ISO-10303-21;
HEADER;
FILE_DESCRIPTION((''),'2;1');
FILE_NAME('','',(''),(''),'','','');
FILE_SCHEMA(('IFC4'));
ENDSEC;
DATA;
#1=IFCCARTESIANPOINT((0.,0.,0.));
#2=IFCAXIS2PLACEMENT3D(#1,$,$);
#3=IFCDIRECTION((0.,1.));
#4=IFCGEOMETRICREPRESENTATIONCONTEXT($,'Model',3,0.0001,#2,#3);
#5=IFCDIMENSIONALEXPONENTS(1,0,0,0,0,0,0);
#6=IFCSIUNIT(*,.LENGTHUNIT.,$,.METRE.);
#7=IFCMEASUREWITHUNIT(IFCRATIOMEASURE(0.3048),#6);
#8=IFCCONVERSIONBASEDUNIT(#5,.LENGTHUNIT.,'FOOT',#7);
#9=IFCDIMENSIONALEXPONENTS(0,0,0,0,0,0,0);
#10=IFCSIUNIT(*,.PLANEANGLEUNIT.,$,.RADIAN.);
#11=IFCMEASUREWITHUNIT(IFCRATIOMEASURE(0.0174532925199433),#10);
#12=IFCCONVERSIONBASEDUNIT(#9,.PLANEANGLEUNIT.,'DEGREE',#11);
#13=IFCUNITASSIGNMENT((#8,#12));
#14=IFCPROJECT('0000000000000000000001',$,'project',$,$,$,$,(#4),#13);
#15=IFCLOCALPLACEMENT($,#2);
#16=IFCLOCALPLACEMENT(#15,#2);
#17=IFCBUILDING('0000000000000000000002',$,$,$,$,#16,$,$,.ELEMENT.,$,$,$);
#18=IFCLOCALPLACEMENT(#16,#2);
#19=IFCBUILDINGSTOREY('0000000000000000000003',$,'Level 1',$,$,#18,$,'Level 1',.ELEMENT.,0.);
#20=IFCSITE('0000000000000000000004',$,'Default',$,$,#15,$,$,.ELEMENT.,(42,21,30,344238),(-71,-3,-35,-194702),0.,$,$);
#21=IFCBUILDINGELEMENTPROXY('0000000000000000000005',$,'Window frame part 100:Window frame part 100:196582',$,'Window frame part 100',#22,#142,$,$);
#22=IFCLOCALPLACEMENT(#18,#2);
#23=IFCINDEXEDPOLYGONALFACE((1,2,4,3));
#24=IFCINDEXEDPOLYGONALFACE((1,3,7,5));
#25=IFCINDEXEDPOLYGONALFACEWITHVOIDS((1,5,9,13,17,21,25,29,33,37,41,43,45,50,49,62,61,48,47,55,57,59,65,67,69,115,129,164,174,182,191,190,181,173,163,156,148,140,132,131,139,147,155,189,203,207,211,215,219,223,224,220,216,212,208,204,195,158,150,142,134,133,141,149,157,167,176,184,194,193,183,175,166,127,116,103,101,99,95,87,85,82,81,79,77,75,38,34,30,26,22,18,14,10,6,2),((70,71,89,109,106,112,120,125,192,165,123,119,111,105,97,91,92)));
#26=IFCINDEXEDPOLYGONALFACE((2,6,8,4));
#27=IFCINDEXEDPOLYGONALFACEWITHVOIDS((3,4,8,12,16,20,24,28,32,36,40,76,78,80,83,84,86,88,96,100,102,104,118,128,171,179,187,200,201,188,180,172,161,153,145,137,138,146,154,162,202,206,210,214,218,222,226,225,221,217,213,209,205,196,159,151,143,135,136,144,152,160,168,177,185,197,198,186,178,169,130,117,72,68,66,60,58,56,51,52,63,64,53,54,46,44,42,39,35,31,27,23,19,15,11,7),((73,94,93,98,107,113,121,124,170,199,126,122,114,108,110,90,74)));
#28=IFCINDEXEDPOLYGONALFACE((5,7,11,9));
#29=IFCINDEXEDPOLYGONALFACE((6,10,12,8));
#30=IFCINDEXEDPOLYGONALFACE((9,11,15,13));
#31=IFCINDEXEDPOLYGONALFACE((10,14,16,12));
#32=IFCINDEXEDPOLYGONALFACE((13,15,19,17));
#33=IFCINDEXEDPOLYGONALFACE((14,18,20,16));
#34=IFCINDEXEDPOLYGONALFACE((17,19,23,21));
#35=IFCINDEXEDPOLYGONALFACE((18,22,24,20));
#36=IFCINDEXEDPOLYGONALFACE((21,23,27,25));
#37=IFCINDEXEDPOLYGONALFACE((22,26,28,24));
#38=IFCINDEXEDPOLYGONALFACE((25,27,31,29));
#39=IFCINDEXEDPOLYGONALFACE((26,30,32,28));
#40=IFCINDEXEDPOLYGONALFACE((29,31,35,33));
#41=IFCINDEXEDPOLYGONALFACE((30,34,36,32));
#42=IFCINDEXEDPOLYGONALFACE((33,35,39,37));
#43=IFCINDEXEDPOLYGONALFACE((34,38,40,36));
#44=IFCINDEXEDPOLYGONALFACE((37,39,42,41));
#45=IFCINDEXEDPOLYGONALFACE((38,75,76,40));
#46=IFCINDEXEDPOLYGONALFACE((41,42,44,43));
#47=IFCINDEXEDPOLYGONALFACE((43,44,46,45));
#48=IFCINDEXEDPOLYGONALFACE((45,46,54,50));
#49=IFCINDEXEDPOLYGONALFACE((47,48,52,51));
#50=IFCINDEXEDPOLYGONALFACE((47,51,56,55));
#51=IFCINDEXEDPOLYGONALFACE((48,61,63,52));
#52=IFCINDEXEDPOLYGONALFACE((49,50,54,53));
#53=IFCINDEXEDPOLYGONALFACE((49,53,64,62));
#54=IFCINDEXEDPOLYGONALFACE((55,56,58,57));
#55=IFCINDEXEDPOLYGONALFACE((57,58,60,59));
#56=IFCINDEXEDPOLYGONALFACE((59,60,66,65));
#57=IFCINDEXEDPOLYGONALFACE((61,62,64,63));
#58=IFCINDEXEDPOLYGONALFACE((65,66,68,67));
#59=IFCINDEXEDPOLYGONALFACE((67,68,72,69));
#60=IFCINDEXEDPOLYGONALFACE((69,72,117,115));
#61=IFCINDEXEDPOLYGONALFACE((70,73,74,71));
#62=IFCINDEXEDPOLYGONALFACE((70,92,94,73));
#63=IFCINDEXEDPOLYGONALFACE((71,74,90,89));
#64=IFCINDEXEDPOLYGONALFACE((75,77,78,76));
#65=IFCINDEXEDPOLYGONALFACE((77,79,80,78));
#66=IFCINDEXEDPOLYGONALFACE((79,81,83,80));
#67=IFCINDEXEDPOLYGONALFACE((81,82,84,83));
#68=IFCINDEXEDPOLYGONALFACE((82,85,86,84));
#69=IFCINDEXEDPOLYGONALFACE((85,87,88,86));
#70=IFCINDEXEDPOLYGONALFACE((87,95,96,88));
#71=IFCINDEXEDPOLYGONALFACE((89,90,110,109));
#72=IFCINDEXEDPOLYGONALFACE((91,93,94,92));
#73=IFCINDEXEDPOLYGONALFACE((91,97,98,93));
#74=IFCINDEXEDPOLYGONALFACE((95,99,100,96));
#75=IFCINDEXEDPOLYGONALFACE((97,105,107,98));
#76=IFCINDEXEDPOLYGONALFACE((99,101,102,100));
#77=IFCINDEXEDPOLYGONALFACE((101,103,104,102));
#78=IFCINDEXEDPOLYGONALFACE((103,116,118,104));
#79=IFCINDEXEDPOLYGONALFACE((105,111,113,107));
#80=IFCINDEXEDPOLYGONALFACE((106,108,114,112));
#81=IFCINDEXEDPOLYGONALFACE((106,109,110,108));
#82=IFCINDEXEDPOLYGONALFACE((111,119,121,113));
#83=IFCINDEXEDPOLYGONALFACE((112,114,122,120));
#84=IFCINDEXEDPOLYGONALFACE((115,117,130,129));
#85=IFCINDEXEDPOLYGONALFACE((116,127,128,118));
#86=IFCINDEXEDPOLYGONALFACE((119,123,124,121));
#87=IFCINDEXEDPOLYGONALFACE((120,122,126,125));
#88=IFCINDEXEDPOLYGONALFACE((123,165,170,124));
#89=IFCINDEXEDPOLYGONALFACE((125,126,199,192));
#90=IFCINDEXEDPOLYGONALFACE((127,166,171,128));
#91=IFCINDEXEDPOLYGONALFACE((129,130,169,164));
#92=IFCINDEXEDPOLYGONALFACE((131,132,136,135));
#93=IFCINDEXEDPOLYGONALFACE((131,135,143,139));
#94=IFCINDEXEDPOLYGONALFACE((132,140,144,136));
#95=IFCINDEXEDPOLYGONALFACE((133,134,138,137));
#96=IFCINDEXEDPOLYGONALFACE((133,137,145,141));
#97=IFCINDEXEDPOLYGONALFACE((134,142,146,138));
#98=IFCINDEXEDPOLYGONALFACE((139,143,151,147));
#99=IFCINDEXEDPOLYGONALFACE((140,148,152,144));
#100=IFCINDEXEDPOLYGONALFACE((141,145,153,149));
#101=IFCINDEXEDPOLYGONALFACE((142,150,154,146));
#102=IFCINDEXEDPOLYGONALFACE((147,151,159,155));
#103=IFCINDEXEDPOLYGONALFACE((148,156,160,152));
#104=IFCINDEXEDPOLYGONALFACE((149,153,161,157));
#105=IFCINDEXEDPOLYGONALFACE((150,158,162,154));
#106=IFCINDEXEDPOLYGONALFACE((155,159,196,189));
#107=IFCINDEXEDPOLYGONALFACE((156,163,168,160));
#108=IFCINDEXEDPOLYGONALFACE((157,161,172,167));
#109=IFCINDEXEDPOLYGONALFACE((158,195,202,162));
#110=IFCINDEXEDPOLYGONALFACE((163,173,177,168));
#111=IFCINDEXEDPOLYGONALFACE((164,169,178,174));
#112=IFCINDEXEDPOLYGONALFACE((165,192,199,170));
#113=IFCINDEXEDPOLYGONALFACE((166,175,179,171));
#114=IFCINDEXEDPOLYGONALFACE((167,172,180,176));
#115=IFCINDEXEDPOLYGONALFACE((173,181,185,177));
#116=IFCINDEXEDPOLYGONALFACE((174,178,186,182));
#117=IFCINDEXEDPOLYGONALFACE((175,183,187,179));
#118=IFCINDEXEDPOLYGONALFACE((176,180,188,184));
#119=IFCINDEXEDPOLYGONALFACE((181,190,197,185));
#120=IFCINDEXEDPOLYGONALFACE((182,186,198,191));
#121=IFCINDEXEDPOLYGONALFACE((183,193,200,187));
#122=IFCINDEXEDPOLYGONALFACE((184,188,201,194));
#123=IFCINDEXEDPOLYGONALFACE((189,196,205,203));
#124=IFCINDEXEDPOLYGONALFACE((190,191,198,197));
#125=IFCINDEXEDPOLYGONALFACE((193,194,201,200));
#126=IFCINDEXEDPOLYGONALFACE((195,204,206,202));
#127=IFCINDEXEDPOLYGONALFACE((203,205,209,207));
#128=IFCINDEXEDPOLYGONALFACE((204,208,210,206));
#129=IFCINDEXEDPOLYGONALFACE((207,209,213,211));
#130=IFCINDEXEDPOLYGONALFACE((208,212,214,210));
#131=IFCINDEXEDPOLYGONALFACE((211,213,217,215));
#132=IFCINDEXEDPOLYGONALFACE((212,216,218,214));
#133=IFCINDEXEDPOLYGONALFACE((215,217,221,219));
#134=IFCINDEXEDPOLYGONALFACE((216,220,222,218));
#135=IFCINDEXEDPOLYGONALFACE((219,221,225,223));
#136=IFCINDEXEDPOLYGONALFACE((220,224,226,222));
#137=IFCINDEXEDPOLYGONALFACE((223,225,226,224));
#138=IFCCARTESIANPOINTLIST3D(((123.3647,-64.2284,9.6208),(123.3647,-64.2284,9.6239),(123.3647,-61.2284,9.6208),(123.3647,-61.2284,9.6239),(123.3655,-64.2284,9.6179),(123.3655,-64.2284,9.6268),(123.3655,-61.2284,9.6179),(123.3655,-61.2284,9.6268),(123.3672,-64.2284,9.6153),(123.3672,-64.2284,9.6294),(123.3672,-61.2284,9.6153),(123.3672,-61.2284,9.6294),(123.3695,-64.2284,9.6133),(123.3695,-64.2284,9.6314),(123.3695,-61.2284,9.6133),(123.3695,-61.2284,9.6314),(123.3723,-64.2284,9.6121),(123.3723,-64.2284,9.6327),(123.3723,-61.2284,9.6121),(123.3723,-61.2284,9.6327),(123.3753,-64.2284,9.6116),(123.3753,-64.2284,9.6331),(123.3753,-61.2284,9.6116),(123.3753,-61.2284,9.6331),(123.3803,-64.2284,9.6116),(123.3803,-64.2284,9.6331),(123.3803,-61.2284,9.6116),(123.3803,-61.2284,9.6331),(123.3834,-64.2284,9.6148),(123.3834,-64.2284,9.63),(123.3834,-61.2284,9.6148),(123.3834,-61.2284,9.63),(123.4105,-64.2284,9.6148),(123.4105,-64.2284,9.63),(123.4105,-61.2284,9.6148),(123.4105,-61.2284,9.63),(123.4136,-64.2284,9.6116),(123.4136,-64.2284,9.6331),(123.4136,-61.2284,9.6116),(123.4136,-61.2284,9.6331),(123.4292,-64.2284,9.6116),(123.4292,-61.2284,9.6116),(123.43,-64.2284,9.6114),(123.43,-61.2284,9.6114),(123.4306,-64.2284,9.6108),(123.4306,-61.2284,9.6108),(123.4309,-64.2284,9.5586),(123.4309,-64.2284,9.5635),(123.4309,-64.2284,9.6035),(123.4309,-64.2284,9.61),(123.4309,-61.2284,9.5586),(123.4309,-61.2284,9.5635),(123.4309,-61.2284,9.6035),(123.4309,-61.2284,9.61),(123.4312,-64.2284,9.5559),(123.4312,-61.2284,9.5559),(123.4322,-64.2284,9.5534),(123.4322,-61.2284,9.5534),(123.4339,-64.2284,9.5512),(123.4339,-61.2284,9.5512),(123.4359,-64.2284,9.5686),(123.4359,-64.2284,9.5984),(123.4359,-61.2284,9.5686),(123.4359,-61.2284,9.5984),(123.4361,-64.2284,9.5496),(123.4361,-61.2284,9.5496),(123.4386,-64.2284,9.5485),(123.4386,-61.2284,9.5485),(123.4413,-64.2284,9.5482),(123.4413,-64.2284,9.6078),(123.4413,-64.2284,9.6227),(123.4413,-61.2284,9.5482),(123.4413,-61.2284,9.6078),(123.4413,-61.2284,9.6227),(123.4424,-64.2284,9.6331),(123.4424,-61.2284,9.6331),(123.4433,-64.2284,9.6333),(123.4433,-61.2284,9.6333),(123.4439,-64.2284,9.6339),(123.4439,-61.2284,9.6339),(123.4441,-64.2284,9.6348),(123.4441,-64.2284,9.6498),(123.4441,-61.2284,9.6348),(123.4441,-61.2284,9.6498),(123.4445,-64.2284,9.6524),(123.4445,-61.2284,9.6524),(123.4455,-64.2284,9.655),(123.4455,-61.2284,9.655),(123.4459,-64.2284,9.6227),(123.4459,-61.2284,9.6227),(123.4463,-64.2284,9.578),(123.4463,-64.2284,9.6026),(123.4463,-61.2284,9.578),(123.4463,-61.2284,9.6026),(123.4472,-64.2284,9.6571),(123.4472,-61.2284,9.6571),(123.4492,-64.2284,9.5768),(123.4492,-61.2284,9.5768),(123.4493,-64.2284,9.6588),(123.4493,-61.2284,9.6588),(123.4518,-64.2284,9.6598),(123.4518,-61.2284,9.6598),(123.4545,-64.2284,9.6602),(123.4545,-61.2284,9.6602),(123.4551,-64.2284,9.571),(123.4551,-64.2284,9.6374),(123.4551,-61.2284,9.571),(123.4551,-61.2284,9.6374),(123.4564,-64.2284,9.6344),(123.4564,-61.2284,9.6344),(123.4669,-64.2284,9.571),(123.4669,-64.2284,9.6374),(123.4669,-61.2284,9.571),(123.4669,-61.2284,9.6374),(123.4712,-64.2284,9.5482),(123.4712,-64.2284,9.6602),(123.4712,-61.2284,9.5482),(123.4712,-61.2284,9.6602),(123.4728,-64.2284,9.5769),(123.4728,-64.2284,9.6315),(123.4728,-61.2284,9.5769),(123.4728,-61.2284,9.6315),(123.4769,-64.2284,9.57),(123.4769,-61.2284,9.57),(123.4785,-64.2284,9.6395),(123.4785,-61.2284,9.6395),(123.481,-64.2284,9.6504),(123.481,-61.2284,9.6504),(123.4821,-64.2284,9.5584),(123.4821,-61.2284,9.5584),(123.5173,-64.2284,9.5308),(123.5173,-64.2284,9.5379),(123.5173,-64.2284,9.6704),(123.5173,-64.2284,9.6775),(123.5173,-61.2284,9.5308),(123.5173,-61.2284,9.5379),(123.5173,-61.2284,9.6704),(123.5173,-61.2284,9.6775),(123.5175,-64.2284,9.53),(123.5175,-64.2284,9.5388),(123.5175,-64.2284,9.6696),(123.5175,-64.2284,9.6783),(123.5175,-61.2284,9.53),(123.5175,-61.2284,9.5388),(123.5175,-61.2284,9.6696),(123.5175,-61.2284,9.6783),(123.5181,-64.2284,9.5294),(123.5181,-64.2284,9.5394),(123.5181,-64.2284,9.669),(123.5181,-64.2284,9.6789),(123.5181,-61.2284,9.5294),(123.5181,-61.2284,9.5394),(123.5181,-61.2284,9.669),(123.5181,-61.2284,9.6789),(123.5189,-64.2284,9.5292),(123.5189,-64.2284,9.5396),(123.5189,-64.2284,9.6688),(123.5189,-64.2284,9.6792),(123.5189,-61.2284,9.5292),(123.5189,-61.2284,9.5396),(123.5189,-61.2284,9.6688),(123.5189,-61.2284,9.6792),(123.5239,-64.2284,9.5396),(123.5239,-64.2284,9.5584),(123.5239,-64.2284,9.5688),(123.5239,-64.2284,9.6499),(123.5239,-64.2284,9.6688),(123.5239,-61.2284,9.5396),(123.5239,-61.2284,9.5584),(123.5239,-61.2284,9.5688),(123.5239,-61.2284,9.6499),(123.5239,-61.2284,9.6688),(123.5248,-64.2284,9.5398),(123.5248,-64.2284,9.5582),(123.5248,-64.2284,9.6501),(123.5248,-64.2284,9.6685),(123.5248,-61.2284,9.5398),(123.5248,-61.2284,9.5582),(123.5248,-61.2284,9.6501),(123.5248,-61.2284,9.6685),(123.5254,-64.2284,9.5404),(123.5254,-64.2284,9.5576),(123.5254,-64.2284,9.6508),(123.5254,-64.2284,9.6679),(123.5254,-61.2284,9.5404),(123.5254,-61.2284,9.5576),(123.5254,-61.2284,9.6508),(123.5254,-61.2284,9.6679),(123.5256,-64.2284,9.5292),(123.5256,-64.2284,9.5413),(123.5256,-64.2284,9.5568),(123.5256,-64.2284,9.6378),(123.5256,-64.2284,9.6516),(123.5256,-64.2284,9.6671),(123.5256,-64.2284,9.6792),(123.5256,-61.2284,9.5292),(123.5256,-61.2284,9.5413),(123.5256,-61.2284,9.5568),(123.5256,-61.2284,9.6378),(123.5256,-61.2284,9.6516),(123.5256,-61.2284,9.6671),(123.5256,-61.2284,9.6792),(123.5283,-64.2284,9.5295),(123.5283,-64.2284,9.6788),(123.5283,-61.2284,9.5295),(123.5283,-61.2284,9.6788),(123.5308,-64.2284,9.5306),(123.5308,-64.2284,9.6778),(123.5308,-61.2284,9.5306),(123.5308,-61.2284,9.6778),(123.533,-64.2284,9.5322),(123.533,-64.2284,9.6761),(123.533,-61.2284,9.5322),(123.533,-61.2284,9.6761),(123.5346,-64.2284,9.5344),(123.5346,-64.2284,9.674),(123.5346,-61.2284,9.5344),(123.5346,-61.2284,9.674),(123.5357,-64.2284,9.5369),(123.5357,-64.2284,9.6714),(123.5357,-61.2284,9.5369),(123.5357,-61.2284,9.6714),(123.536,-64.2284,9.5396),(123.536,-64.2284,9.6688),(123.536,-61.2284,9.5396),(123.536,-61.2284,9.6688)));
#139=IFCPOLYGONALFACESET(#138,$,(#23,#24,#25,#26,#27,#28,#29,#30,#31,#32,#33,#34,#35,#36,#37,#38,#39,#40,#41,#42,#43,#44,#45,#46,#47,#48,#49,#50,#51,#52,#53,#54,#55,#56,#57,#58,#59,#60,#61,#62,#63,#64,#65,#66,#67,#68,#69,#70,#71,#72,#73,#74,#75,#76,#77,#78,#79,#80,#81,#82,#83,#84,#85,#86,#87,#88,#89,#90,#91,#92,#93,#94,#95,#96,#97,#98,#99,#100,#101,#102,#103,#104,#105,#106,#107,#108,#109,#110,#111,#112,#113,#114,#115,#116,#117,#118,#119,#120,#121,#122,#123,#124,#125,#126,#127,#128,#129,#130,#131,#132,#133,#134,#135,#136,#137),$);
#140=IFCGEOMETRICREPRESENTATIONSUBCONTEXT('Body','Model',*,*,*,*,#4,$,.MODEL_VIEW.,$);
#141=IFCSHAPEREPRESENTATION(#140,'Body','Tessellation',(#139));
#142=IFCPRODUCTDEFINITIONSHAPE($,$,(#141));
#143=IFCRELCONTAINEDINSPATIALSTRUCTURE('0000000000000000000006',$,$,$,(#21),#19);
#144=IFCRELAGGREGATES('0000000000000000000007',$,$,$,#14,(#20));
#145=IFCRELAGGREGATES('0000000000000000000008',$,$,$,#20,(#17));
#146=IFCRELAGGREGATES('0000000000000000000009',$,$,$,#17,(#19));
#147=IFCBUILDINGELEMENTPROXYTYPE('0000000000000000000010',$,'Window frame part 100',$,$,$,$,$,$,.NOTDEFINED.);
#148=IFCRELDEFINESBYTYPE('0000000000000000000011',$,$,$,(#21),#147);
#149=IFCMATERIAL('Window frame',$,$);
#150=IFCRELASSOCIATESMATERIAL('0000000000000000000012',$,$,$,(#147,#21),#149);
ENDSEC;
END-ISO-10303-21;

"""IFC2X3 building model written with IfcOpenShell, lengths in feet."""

from ifc_helpers import new_model, entity, si_unit, converted_unit, direction, frame, frame_2d, origin, place, context, subcontext, project, spatial, polyline, circle_curve, parameter, trimmed, segment, composite_curve, outline, extrude, source, transform, mapped, material, type_object, type_shapes, element, save


model = new_model("IFC2X3")

# Units and contexts
model_context = context("Model", 3, precision=0.0001, world=origin(), true_north=direction((0.0, 1.0)))
body_context = subcontext(model_context, "Body", "Model", "MODEL_VIEW")
ifc_project = project(units=[converted_unit("LENGTHUNIT", "FOOT", entity("IfcRatioMeasure", 0.3048), si_unit("LENGTHUNIT", "METRE"), dimensions=[1, 0, 0, 0, 0, 0, 0]), converted_unit("PLANEANGLEUNIT", "DEGREE", entity("IfcRatioMeasure", 0.0174532925199433), si_unit("PLANEANGLEUNIT", "RADIAN"), dimensions=[0, 0, 0, 0, 0, 0, 0])], contexts=[model_context])

# Site, building, storey
site_placement = place(None, origin())
site = spatial("IfcSite", under=ifc_project, at=site_placement, Name="Default", CompositionType="ELEMENT", RefLatitude=(42, 21, 30, 344238), RefLongitude=(-71, -3, -35, -194702), RefElevation=0.0)
building_placement = place(site_placement, origin())
building = spatial("IfcBuilding", under=site, at=building_placement, CompositionType="ELEMENT")
storey_placement = place(building_placement, origin())
storey = spatial("IfcBuildingStorey", under=building, at=storey_placement, Name="Level 1", LongName="Level 1", CompositionType="ELEMENT", Elevation=0.0)

# Building element proxy
ifc_material_1 = material(Name="Window frame")
building_element_proxy_type_1 = type_object("IfcBuildingElementProxyType", Name="Window frame part 100", PredefinedType="NOTDEFINED", material=ifc_material_1)
shared_shape_1 = source(origin(), body_context, "Body", "SweptSolid", [
    extrude(outline(composite_curve([segment(polyline([(-0.0044, 0.0376), (-0.0095, 0.0326)]), True, "CONTINUOUS"), segment(polyline([(-0.0095, 0.0326), (-0.0394, 0.0326)]), True, "CONTINUOUS"), segment(polyline([(-0.0394, 0.0326), (-0.0444, 0.0376)]), True, "CONTINUOUS"), segment(polyline([(-0.0444, 0.0376), (-0.0493, 0.0376)]), True, "CONTINUOUS"), segment(trimmed(circle_curve(frame_2d((-0.0493, 0.0272), x_axis=(0.0, -1.0)), 0.0104), [parameter(180.0)], [parameter(270.0)], True, "PARAMETER"), True, "CONTINUOUS"), segment(polyline([(-0.0598, 0.0272), (-0.0598, -0.0027)]), True, "CONTINUOUS"), segment(polyline([(-0.0598, -0.0027), (-0.0495, -0.0137)]), True, "CONTINUOUS"), segment(polyline([(-0.0495, -0.0137), (-0.0495, -0.0555)]), True, "CONTINUOUS"), segment(trimmed(circle_curve(frame_2d((-0.0512, -0.0555), x_axis=(0.0, -1.0)), 0.0017), [parameter(0.0)], [parameter(90.0)], True, "PARAMETER"), False, "CONTINUOUS"), segment(polyline([(-0.0512, -0.0572), (-0.0667, -0.0572)]), True, "CONTINUOUS"), segment(trimmed(circle_curve(frame_2d((-0.0667, -0.0555), x_axis=(0.0, -1.0)), 0.0017), [parameter(270.0)], [parameter(0.0)], True, "PARAMETER"), False, "CONTINUOUS"), segment(polyline([(-0.0683, -0.0555), (-0.0683, -0.0505)]), True, "CONTINUOUS"), segment(trimmed(circle_curve(frame_2d((-0.07, -0.0505), x_axis=(0.0, -1.0)), 0.0017), [parameter(90.0)], [parameter(180.0)], True, "PARAMETER"), True, "CONTINUOUS"), segment(polyline([(-0.07, -0.0488), (-0.0771, -0.0488)]), True, "CONTINUOUS"), segment(trimmed(circle_curve(frame_2d((-0.0771, -0.0505), x_axis=(0.0, -1.0)), 0.0017), [parameter(180.0)], [parameter(270.0)], True, "PARAMETER"), True, "CONTINUOUS"), segment(polyline([(-0.0788, -0.0505), (-0.0788, -0.0572)]), True, "CONTINUOUS"), segment(trimmed(circle_curve(frame_2d((-0.0683, -0.0572), x_axis=(0.0, -1.0)), 0.0104), [parameter(270.0)], [parameter(0.0)], True, "PARAMETER"), True, "CONTINUOUS"), segment(polyline([(-0.0683, -0.0676), (0.0608, -0.0676)]), True, "CONTINUOUS"), segment(trimmed(circle_curve(frame_2d((0.0608, -0.0572), x_axis=(0.0, -1.0)), 0.0104), [parameter(0.0)], [parameter(90.0)], True, "PARAMETER"), True, "CONTINUOUS"), segment(polyline([(0.0712, -0.0572), (0.0712, -0.0505)]), True, "CONTINUOUS"), segment(trimmed(circle_curve(frame_2d((0.0696, -0.0505), x_axis=(0.0, -1.0)), 0.0017), [parameter(90.0)], [parameter(180.0)], True, "PARAMETER"), True, "CONTINUOUS"), segment(polyline([(0.0696, -0.0488), (0.0625, -0.0488)]), True, "CONTINUOUS"), segment(trimmed(circle_curve(frame_2d((0.0625, -0.0505), x_axis=(0.0, -1.0)), 0.0017), [parameter(180.0)], [parameter(270.0)], True, "PARAMETER"), True, "CONTINUOUS"), segment(polyline([(0.0608, -0.0505), (0.0608, -0.0555)]), True, "CONTINUOUS"), segment(trimmed(circle_curve(frame_2d((0.0592, -0.0555), x_axis=(0.0, -1.0)), 0.0017), [parameter(0.0)], [parameter(90.0)], True, "PARAMETER"), False, "CONTINUOUS"), segment(polyline([(0.0592, -0.0572), (0.0437, -0.0572)]), True, "CONTINUOUS"), segment(trimmed(circle_curve(frame_2d((0.0437, -0.0555), x_axis=(0.0, -1.0)), 0.0017), [parameter(270.000001)], [parameter(0.0)], True, "PARAMETER"), False, "CONTINUOUS"), segment(polyline([(0.042, -0.0555), (0.0425, -0.0125)]), True, "CONTINUOUS"), segment(polyline([(0.0425, -0.0125), (0.0522, -0.0027)]), True, "CONTINUOUS"), segment(polyline([(0.0522, -0.0027), (0.0522, 0.0139)]), True, "CONTINUOUS"), segment(trimmed(circle_curve(frame_2d((0.0418, 0.0139), x_axis=(0.0, -1.0)), 0.0104), [parameter(90.0)], [parameter(180.0)], True, "PARAMETER"), True, "CONTINUOUS"), segment(polyline([(0.0418, 0.0243), (0.0268, 0.0243)]), True, "CONTINUOUS"), segment(trimmed(circle_curve(frame_2d((0.0268, 0.026), x_axis=(0.0, -1.0)), 0.0017), [parameter(270.0)], [parameter(0.0)], True, "PARAMETER"), False, "CONTINUOUS"), segment(polyline([(0.0252, 0.026), (0.0252, 0.0548)]), True, "CONTINUOUS"), segment(polyline([(0.0252, 0.0548), (0.0221, 0.0579)]), True, "CONTINUOUS"), segment(polyline([(0.0221, 0.0579), (0.0221, 0.085)]), True, "CONTINUOUS"), segment(polyline([(0.0221, 0.085), (0.0252, 0.0882)]), True, "CONTINUOUS"), segment(polyline([(0.0252, 0.0882), (0.0252, 0.0932)]), True, "CONTINUOUS"), segment(trimmed(circle_curve(frame_2d((0.0145, 0.0932), x_axis=(0.0, -1.0)), 0.0107), [parameter(90.0)], [parameter(270.0)], True, "PARAMETER"), True, "CONTINUOUS"), segment(polyline([(0.0037, 0.0932), (0.0037, 0.0882)]), True, "CONTINUOUS"), segment(polyline([(0.0037, 0.0882), (0.0068, 0.085)]), True, "CONTINUOUS"), segment(polyline([(0.0068, 0.085), (0.0068, 0.0579)]), True, "CONTINUOUS"), segment(polyline([(0.0068, 0.0579), (0.0037, 0.0548)]), True, "CONTINUOUS"), segment(polyline([(0.0037, 0.0548), (0.0037, 0.0393)]), True, "CONTINUOUS"), segment(trimmed(circle_curve(frame_2d((0.0021, 0.0393), x_axis=(0.0, -1.0)), 0.0017), [parameter(0.0)], [parameter(90.0)], True, "PARAMETER"), False, "CONTINUOUS"), segment(polyline([(0.0021, 0.0376), (-0.0044, 0.0376)]), True, "CONTINUOUS")], self_intersect=False), holes=[polyline([(-0.03, 0.0222), (-0.0053, 0.0222), (-0.0001, 0.0272), (0.0148, 0.0272), (0.0148, 0.0225), (0.0265, 0.0121), (0.0294, 0.0133), (0.0294, 0.0015), (0.0235, -0.0043), (0.0316, -0.0101), (0.0299, -0.0572), (-0.0391, -0.0555), (-0.0379, -0.0085), (-0.031, -0.0043), (-0.0369, 0.0015), (-0.0369, 0.0133), (-0.0311, 0.0193), (-0.03, 0.0222)])]), frame((123.4685, -64.2284, 9.6079), z_axis=(0.0, -1.0, 0.0), x_axis=(0.0, 0.0, 1.0)), (0.0, 0.0, -1.0), 3.0),
])
type_shapes(building_element_proxy_type_1, [shared_shape_1])
proxy_1_placement = place(storey_placement, origin())
element("IfcBuildingElementProxy", 1, at=proxy_1_placement, inside=storey, type_object=building_element_proxy_type_1, material=ifc_material_1, Name="Window frame part 100:Window frame part 100:196582", ObjectType="Window frame part 100", context=body_context, shape_type="MappedRepresentation", body=[
    mapped(shared_shape_1, transform((0.0, 0.0, 0.0), scale=1.0)),
])

save(model, "model.ifc")
